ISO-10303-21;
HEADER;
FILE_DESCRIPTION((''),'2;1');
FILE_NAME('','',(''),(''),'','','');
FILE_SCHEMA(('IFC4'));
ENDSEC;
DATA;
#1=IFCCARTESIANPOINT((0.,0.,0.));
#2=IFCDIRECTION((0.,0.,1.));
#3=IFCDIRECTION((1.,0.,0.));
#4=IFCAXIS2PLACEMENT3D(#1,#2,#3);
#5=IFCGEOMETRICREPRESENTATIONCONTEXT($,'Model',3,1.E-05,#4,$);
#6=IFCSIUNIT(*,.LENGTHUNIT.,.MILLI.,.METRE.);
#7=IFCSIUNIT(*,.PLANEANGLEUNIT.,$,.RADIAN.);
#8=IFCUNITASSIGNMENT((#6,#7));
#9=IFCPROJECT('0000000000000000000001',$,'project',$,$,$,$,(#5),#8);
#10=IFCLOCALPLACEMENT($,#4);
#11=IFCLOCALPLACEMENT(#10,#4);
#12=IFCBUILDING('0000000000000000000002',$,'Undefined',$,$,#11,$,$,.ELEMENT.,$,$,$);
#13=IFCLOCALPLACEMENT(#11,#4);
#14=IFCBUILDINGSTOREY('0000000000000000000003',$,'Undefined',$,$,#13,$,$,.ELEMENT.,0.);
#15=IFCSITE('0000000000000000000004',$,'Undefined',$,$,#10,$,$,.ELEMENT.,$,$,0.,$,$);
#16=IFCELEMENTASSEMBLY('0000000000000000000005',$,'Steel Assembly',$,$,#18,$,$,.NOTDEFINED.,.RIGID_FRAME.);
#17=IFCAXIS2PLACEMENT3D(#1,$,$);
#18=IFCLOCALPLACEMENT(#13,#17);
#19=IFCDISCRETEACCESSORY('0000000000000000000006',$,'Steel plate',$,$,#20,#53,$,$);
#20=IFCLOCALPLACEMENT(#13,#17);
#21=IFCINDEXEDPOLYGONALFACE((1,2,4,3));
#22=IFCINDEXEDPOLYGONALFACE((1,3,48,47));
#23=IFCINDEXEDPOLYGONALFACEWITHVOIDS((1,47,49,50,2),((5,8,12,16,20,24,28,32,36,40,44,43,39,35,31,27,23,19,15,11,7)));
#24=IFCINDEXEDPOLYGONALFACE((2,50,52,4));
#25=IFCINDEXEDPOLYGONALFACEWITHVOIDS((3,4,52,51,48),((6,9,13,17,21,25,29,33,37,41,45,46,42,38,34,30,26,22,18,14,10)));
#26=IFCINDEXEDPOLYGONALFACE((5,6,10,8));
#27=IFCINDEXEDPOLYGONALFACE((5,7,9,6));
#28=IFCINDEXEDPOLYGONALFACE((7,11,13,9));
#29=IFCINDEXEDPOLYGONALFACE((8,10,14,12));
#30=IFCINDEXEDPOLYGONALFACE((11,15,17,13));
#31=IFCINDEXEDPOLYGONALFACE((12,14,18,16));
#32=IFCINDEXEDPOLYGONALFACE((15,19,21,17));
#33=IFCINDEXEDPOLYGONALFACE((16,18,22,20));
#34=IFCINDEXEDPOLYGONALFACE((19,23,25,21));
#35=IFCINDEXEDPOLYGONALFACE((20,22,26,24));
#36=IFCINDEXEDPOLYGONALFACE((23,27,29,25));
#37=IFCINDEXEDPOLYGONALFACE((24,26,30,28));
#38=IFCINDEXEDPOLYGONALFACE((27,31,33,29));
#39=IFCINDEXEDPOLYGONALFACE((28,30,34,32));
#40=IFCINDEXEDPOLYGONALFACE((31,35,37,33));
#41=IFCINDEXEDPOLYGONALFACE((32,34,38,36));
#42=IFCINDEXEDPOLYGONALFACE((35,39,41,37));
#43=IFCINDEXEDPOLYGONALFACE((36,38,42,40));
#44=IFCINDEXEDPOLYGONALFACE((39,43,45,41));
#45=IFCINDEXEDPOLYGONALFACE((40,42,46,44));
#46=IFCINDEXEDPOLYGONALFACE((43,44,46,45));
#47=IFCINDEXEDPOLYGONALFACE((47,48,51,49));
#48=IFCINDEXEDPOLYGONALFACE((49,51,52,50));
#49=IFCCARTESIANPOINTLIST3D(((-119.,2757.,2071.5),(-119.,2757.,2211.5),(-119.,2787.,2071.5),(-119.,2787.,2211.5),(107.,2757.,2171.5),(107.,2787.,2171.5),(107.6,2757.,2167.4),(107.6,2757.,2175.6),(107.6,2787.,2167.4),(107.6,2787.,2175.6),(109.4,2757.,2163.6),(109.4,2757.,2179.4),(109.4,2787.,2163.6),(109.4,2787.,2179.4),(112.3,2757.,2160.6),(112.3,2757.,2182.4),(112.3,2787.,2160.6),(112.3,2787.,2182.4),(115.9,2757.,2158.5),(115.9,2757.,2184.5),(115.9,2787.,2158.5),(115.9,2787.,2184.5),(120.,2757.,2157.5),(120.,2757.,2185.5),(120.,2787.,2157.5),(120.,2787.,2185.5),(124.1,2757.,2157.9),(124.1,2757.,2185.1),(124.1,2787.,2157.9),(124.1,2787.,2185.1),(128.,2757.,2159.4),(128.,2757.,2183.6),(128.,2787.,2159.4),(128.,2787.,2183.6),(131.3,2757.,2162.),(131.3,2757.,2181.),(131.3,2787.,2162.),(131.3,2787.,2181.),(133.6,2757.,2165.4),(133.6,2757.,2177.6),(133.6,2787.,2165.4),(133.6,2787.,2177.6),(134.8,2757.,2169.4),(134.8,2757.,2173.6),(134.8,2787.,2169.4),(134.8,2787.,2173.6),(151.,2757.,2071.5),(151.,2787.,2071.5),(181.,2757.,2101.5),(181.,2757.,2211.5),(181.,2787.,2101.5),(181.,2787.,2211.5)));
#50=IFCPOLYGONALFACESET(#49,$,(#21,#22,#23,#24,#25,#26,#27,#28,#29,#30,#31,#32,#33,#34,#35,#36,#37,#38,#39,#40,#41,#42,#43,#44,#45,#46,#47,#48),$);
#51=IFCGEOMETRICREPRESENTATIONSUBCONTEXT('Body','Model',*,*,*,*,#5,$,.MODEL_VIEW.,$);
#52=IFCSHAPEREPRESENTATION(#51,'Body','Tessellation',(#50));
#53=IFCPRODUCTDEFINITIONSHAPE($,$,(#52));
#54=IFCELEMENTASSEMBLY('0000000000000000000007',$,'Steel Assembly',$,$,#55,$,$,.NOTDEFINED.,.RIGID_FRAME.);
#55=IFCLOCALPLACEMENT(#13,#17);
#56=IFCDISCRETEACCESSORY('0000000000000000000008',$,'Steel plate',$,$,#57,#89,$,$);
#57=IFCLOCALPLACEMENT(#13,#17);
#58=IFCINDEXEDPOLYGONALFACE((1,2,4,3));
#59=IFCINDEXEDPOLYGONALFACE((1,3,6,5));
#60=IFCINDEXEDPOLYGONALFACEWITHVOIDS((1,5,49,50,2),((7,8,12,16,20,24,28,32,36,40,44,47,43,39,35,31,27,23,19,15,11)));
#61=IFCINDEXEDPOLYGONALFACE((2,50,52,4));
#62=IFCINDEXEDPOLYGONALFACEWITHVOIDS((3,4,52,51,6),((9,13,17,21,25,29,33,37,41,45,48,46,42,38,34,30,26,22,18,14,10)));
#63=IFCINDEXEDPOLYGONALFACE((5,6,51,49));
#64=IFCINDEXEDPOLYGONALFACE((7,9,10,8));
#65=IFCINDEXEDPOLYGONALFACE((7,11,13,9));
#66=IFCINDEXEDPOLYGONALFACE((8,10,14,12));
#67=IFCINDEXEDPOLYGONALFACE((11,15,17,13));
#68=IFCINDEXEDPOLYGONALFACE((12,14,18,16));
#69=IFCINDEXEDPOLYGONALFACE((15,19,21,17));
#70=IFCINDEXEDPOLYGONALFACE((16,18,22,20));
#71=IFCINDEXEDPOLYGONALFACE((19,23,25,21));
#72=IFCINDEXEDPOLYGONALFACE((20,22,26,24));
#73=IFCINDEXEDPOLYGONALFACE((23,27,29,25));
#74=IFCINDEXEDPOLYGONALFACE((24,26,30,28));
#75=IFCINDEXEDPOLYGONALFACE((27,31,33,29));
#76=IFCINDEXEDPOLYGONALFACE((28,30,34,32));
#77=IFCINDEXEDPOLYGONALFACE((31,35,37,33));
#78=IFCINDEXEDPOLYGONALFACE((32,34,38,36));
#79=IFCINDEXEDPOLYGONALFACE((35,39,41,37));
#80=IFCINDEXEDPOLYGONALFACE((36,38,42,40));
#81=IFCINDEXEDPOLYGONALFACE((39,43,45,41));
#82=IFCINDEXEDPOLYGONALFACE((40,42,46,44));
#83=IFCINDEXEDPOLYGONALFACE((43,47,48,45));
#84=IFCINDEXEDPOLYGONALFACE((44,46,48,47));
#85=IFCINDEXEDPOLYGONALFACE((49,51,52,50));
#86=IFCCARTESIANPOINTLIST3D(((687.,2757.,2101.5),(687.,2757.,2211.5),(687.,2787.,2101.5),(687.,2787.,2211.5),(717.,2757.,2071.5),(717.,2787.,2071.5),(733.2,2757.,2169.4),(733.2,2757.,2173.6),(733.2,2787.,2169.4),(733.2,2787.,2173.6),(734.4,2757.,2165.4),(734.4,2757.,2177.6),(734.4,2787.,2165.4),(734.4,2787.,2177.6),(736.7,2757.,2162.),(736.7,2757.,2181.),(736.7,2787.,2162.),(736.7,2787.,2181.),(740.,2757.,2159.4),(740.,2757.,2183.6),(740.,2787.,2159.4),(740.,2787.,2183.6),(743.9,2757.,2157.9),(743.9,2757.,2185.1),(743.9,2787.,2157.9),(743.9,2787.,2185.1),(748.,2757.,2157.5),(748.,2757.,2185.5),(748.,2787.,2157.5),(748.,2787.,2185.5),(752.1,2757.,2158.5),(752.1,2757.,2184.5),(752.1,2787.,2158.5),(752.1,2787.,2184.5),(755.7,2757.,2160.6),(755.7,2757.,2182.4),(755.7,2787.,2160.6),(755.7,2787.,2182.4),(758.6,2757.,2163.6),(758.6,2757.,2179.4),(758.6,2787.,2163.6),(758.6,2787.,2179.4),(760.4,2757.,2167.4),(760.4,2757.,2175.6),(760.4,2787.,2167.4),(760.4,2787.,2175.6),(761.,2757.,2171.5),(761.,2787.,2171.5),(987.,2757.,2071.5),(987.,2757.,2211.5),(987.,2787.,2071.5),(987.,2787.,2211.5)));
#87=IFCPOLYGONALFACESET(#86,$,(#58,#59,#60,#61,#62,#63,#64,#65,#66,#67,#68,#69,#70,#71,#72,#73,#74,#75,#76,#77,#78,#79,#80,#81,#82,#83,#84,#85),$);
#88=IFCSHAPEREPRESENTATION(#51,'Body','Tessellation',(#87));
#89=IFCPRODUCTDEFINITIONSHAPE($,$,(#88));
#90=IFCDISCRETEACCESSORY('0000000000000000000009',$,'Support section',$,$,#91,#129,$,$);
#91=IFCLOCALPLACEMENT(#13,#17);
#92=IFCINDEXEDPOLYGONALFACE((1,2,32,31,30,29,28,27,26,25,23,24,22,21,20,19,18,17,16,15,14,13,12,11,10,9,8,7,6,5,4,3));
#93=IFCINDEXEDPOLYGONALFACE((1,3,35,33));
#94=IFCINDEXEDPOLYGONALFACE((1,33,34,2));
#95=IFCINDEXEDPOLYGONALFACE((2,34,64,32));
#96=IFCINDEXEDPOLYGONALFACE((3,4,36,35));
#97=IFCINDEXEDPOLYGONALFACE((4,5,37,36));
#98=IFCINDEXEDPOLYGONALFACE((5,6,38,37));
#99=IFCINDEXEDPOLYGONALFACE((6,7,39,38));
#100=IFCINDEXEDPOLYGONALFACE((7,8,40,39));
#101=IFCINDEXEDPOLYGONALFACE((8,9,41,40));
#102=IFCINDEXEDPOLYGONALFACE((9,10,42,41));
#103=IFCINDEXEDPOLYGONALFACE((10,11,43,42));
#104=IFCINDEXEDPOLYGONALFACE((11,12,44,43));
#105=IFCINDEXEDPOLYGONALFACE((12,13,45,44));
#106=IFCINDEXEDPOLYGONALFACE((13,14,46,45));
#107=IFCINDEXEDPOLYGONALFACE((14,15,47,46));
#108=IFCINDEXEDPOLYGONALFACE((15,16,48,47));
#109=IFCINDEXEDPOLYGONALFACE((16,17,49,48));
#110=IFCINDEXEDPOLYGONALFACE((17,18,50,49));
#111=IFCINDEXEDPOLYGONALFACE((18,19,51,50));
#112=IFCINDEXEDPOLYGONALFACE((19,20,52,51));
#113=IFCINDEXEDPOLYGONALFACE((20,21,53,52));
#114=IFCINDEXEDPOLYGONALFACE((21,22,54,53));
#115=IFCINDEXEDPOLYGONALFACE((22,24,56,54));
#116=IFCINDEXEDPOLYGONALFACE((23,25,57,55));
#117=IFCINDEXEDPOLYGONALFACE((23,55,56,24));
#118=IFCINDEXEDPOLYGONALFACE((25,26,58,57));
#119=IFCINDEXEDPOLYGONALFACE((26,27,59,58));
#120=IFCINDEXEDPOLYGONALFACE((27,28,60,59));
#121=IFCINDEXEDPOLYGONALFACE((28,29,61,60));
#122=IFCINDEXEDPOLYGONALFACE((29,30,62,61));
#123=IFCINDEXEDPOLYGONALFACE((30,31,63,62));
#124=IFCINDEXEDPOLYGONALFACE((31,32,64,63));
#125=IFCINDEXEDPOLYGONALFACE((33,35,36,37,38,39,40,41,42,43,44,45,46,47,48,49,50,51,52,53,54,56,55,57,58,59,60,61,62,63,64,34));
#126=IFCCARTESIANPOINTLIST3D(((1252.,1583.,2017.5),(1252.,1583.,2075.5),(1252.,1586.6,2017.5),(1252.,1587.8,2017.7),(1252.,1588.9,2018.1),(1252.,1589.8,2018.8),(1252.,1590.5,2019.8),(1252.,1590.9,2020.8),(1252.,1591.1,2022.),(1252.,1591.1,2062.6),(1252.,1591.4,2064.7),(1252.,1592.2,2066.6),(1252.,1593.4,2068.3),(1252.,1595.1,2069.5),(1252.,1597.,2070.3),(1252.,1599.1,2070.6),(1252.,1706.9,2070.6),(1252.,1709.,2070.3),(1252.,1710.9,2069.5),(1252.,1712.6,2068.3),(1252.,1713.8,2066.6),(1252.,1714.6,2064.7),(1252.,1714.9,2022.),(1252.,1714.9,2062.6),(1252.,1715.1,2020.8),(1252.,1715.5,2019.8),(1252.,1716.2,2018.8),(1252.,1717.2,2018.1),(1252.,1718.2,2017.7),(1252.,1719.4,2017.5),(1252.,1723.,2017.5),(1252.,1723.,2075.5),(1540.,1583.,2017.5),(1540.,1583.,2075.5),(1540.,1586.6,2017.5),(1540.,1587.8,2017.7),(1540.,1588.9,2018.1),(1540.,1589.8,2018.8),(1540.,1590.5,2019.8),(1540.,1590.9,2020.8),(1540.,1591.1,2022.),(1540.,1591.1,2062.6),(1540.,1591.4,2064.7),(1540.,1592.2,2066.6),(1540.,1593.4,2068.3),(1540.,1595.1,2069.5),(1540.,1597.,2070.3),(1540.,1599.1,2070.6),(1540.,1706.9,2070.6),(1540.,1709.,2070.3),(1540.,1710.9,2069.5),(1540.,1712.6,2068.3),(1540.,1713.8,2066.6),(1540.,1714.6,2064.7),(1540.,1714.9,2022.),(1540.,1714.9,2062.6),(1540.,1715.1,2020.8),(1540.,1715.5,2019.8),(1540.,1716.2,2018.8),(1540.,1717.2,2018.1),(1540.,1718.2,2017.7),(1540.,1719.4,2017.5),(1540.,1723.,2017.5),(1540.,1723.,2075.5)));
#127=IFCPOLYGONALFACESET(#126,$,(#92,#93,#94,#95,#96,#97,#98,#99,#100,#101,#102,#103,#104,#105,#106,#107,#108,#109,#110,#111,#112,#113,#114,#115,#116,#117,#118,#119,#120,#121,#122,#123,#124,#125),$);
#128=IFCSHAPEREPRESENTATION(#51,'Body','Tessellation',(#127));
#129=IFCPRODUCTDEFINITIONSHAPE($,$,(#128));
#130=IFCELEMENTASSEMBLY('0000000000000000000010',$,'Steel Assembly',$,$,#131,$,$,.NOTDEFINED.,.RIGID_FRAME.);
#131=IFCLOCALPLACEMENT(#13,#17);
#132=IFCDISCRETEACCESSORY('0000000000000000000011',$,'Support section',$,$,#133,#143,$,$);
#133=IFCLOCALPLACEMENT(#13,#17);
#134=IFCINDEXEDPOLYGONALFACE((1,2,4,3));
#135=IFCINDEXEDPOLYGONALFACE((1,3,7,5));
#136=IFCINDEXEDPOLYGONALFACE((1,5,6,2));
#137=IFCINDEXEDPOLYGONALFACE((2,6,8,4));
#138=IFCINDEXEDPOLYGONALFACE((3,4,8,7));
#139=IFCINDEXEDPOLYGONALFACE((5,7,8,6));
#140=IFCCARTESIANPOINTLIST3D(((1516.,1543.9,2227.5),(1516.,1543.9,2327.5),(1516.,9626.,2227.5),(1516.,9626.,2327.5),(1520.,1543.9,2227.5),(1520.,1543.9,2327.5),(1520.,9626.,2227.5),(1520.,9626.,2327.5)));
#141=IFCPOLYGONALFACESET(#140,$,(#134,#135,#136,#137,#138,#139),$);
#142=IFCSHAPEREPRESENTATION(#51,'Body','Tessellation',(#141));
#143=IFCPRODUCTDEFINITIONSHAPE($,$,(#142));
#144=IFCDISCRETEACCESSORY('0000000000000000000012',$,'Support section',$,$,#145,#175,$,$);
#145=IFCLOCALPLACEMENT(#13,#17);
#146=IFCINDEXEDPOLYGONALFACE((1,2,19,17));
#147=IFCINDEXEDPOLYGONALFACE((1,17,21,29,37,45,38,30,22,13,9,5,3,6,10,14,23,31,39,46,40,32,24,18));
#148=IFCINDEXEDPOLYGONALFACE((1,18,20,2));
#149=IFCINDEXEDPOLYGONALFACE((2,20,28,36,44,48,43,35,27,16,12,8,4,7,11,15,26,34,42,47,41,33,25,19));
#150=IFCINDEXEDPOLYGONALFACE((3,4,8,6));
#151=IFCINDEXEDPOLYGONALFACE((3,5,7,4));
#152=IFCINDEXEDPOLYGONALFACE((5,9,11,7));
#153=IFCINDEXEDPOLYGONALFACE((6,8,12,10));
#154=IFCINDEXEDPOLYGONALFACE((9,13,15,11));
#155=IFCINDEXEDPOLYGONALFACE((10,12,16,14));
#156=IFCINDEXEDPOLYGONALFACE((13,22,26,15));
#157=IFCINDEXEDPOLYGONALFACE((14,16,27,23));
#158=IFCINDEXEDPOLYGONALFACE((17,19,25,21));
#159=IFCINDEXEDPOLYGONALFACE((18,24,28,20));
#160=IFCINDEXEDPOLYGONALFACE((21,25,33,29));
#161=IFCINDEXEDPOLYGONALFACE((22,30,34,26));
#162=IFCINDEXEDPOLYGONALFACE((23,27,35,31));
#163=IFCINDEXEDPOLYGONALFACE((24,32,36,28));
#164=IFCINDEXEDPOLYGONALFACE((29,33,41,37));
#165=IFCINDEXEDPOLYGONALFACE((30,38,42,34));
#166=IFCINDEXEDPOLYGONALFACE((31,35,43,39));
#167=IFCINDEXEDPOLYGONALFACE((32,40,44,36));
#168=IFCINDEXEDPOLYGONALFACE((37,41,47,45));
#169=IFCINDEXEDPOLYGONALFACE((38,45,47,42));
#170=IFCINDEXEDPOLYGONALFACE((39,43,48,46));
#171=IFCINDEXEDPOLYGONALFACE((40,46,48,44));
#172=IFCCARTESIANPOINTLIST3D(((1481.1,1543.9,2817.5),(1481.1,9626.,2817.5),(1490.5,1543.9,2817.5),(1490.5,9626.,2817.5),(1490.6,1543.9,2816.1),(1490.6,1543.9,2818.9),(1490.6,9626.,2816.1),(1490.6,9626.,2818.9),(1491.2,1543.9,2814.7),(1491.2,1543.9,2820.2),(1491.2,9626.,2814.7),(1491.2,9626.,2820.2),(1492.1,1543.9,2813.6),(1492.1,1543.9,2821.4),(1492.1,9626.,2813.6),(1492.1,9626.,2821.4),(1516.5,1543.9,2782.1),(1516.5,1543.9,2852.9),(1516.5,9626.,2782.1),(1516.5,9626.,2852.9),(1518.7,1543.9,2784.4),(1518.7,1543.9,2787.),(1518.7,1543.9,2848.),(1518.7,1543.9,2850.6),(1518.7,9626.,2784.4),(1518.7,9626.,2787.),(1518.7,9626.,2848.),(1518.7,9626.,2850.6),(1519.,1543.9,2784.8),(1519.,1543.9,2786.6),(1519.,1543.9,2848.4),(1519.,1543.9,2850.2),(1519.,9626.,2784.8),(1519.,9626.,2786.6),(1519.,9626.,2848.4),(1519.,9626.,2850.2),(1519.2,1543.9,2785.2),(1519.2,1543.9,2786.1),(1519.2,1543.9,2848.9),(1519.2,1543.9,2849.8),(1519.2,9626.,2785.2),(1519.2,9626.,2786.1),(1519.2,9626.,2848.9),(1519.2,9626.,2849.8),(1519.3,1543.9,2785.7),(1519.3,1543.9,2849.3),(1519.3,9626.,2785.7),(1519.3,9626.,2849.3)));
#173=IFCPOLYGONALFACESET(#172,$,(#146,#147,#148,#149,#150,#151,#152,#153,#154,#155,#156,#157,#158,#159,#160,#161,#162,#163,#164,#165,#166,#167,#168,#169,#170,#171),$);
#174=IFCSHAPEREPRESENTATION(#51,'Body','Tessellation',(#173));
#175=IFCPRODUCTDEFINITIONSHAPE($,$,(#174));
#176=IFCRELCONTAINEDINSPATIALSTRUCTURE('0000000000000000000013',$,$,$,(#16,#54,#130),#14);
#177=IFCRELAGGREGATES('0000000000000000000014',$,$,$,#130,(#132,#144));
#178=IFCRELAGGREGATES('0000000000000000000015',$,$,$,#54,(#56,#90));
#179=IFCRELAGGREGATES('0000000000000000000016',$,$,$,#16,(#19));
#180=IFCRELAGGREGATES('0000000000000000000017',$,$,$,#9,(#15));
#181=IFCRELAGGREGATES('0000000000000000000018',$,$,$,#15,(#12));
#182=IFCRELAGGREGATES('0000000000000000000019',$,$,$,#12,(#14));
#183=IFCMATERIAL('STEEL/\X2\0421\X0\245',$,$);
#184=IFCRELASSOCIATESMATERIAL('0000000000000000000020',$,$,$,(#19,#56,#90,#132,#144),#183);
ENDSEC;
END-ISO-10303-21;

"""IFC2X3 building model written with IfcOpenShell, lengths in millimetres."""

from ifc_helpers import new_model, si_unit, frame, origin_with_axes, origin_2d_with_axis, place, context, subcontext, project, spatial, polyline, rectangle, circle, l_section, u_section, outline, extrude, source, transform, mapped, material, element, aggregate, save


model = new_model("IFC2X3")

# Units and contexts
model_context = context("Model", 3, precision=1e-05, world=origin_with_axes())
body_context = subcontext(model_context, "Body", "Model", "MODEL_VIEW")
ifc_project = project(units=[si_unit("LENGTHUNIT", "METRE", prefix="MILLI"), si_unit("PLANEANGLEUNIT", "RADIAN")], contexts=[model_context])

# Site, building, storey
site_placement = place(None, origin_with_axes())
site = spatial("IfcSite", under=ifc_project, at=site_placement, Name="Undefined", CompositionType="ELEMENT", RefElevation=0.0)
building_placement = place(site_placement, origin_with_axes())
building = spatial("IfcBuilding", under=site, at=building_placement, Name="Undefined", CompositionType="ELEMENT")
storey_placement = place(building_placement, origin_with_axes())
storey = spatial("IfcBuildingStorey", under=building, at=storey_placement, Name="Undefined", CompositionType="ELEMENT", Elevation=0.0)

# Shared definitions
ifc_material_1 = material(Name="STEEL/С245")

# Element assembly, discrete accessory, opening
assembly_1_placement = place(storey_placement, origin_with_axes())
assembly_1 = element("IfcElementAssembly", 1, at=assembly_1_placement, inside=storey, Name="Steel Assembly", AssemblyPlace="NOTDEFINED", PredefinedType="RIGID_FRAME")
discrete_accessory_1_placement = place(assembly_1_placement, frame((181.0, 2772.0, 2211.5), z_axis=(0.0, 1.0, 0.0), x_axis=(0.0, 0.0, -1.0)))
discrete_accessory_1 = element("IfcDiscreteAccessory", 2, at=discrete_accessory_1_placement, material=ifc_material_1, Name="Steel plate", context=body_context, shape_type="SweptSolid", body=[
    extrude(outline(polyline([(0.0, 0.0), (110.0, 0.0), (140.0, 30.0), (140.0, 300.0), (0.0, 300.0), (0.0, 0.0)])), frame((0.0, 0.0, -15.0), z_axis=(0.0, 0.0, 1.0), x_axis=(1.0, 0.0, 0.0)), (0.0, 0.0, 1.0), 30.0),
])
shared_shape_1 = source(origin_with_axes(), body_context, "Body", "SweptSolid", [
    extrude(circle(Radius=14.0, at=origin_2d_with_axis()), frame((0.0, -15.1, 0.0), z_axis=(0.0, 1.0, 0.0), x_axis=(1.0, 0.0, 0.0)), (0.0, 0.0, 1.0), 45.3),
])
opening_1_placement = place(assembly_1_placement, frame((121.0, 2772.0, 2171.5), z_axis=(0.0, 0.0, 1.0), x_axis=(-1.0, 0.0, 0.0)))
element("IfcOpeningElement", 3, at=opening_1_placement, cuts=discrete_accessory_1, ObjectType="Opening", context=body_context, shape_type="MappedRepresentation", body=[
    mapped(shared_shape_1, transform((0.0, 0.0, 0.0))),
])

# Element assemblies, discrete accessories, opening
assembly_2_placement = place(storey_placement, origin_with_axes())
assembly_2 = element("IfcElementAssembly", 4, at=assembly_2_placement, inside=storey, Name="Steel Assembly", AssemblyPlace="NOTDEFINED", PredefinedType="RIGID_FRAME")
discrete_accessory_2_placement = place(assembly_2_placement, frame((687.0, 2772.0, 2211.5), z_axis=(0.0, -1.0, 0.0), x_axis=(0.0, 0.0, -1.0)))
discrete_accessory_2 = element("IfcDiscreteAccessory", 5, at=discrete_accessory_2_placement, material=ifc_material_1, Name="Steel plate", context=body_context, shape_type="SweptSolid", body=[
    extrude(outline(polyline([(0.0, 0.0), (110.0, 0.0), (140.0, 30.0), (140.0, 300.0), (0.0, 300.0), (0.0, 0.0)])), frame((0.0, 0.0, -15.0), z_axis=(0.0, 0.0, 1.0), x_axis=(1.0, 0.0, 0.0)), (0.0, 0.0, 1.0), 30.0),
])
opening_2_placement = place(assembly_2_placement, frame((747.0, 2772.0, 2171.5), z_axis=(0.0, 0.0, 1.0), x_axis=(1.0, 0.0, 0.0)))
element("IfcOpeningElement", 6, at=opening_2_placement, cuts=discrete_accessory_2, ObjectType="Opening", context=body_context, shape_type="MappedRepresentation", body=[
    mapped(shared_shape_1, transform((0.0, 0.0, 0.0))),
])
discrete_accessory_3_placement = place(assembly_2_placement, frame((1252.0, 1653.0, 2046.5), z_axis=(0.0, -1.0, 0.0), x_axis=(1.0, 0.0, 0.0)))
discrete_accessory_3 = element("IfcDiscreteAccessory", 7, at=discrete_accessory_3_placement, material=ifc_material_1, Name="Support section", context=body_context, shape_type="SweptSolid", body=[
    extrude(u_section(Depth=140.0, FlangeWidth=58.0, WebThickness=4.9, FlangeThickness=8.1, FilletRadius=8.0, EdgeRadius=4.5, at=origin_2d_with_axis()), frame((288.0, 0.0, 0.0), z_axis=(-1.0, 0.0, 0.0), x_axis=(0.0, -1.0, 0.0)), (0.0, 0.0, 1.0), 288.0),
])
assembly_3_placement = place(storey_placement, origin_with_axes())
assembly_3 = element("IfcElementAssembly", 8, at=assembly_3_placement, inside=storey, Name="Steel Assembly", AssemblyPlace="NOTDEFINED", PredefinedType="RIGID_FRAME")
discrete_accessory_4_placement = place(assembly_3_placement, frame((1518.0, 1543.9, 2277.5), z_axis=(0.0, 0.0, 1.0), x_axis=(0.0, 1.0, 0.0)))
discrete_accessory_4 = element("IfcDiscreteAccessory", 9, at=discrete_accessory_4_placement, material=ifc_material_1, Name="Support section", context=body_context, shape_type="SweptSolid", body=[
    extrude(rectangle(XDim=4.0, YDim=100.0, at=origin_2d_with_axis()), frame((8082.1, 0.0, 0.0), z_axis=(-1.0, 0.0, 0.0), x_axis=(0.0, -1.0, 0.0)), (0.0, 0.0, 1.0), 8082.1),
])
discrete_accessory_5_placement = place(assembly_3_placement, frame((1516.5, 1543.9, 2817.5), z_axis=(0.707107, 0.0, 0.707107), x_axis=(0.0, 1.0, 0.0)))
discrete_accessory_5 = element("IfcDiscreteAccessory", 10, at=discrete_accessory_5_placement, material=ifc_material_1, Name="Support section", context=body_context, shape_type="SweptSolid", body=[
    extrude(l_section(Depth=50.0, Width=50.0, Thickness=5.0, FilletRadius=5.5, EdgeRadius=1.8, at=origin_2d_with_axis()), frame((8082.1, 0.0, 0.0), z_axis=(-1.0, 0.0, 0.0), x_axis=(0.0, -1.0, 0.0)), (0.0, 0.0, 1.0), 8082.1),
])
aggregate(assembly_3, [discrete_accessory_4, discrete_accessory_5])

aggregate(assembly_2, [discrete_accessory_2, discrete_accessory_3])

aggregate(assembly_1, [discrete_accessory_1])

save(model, "model.ifc")
